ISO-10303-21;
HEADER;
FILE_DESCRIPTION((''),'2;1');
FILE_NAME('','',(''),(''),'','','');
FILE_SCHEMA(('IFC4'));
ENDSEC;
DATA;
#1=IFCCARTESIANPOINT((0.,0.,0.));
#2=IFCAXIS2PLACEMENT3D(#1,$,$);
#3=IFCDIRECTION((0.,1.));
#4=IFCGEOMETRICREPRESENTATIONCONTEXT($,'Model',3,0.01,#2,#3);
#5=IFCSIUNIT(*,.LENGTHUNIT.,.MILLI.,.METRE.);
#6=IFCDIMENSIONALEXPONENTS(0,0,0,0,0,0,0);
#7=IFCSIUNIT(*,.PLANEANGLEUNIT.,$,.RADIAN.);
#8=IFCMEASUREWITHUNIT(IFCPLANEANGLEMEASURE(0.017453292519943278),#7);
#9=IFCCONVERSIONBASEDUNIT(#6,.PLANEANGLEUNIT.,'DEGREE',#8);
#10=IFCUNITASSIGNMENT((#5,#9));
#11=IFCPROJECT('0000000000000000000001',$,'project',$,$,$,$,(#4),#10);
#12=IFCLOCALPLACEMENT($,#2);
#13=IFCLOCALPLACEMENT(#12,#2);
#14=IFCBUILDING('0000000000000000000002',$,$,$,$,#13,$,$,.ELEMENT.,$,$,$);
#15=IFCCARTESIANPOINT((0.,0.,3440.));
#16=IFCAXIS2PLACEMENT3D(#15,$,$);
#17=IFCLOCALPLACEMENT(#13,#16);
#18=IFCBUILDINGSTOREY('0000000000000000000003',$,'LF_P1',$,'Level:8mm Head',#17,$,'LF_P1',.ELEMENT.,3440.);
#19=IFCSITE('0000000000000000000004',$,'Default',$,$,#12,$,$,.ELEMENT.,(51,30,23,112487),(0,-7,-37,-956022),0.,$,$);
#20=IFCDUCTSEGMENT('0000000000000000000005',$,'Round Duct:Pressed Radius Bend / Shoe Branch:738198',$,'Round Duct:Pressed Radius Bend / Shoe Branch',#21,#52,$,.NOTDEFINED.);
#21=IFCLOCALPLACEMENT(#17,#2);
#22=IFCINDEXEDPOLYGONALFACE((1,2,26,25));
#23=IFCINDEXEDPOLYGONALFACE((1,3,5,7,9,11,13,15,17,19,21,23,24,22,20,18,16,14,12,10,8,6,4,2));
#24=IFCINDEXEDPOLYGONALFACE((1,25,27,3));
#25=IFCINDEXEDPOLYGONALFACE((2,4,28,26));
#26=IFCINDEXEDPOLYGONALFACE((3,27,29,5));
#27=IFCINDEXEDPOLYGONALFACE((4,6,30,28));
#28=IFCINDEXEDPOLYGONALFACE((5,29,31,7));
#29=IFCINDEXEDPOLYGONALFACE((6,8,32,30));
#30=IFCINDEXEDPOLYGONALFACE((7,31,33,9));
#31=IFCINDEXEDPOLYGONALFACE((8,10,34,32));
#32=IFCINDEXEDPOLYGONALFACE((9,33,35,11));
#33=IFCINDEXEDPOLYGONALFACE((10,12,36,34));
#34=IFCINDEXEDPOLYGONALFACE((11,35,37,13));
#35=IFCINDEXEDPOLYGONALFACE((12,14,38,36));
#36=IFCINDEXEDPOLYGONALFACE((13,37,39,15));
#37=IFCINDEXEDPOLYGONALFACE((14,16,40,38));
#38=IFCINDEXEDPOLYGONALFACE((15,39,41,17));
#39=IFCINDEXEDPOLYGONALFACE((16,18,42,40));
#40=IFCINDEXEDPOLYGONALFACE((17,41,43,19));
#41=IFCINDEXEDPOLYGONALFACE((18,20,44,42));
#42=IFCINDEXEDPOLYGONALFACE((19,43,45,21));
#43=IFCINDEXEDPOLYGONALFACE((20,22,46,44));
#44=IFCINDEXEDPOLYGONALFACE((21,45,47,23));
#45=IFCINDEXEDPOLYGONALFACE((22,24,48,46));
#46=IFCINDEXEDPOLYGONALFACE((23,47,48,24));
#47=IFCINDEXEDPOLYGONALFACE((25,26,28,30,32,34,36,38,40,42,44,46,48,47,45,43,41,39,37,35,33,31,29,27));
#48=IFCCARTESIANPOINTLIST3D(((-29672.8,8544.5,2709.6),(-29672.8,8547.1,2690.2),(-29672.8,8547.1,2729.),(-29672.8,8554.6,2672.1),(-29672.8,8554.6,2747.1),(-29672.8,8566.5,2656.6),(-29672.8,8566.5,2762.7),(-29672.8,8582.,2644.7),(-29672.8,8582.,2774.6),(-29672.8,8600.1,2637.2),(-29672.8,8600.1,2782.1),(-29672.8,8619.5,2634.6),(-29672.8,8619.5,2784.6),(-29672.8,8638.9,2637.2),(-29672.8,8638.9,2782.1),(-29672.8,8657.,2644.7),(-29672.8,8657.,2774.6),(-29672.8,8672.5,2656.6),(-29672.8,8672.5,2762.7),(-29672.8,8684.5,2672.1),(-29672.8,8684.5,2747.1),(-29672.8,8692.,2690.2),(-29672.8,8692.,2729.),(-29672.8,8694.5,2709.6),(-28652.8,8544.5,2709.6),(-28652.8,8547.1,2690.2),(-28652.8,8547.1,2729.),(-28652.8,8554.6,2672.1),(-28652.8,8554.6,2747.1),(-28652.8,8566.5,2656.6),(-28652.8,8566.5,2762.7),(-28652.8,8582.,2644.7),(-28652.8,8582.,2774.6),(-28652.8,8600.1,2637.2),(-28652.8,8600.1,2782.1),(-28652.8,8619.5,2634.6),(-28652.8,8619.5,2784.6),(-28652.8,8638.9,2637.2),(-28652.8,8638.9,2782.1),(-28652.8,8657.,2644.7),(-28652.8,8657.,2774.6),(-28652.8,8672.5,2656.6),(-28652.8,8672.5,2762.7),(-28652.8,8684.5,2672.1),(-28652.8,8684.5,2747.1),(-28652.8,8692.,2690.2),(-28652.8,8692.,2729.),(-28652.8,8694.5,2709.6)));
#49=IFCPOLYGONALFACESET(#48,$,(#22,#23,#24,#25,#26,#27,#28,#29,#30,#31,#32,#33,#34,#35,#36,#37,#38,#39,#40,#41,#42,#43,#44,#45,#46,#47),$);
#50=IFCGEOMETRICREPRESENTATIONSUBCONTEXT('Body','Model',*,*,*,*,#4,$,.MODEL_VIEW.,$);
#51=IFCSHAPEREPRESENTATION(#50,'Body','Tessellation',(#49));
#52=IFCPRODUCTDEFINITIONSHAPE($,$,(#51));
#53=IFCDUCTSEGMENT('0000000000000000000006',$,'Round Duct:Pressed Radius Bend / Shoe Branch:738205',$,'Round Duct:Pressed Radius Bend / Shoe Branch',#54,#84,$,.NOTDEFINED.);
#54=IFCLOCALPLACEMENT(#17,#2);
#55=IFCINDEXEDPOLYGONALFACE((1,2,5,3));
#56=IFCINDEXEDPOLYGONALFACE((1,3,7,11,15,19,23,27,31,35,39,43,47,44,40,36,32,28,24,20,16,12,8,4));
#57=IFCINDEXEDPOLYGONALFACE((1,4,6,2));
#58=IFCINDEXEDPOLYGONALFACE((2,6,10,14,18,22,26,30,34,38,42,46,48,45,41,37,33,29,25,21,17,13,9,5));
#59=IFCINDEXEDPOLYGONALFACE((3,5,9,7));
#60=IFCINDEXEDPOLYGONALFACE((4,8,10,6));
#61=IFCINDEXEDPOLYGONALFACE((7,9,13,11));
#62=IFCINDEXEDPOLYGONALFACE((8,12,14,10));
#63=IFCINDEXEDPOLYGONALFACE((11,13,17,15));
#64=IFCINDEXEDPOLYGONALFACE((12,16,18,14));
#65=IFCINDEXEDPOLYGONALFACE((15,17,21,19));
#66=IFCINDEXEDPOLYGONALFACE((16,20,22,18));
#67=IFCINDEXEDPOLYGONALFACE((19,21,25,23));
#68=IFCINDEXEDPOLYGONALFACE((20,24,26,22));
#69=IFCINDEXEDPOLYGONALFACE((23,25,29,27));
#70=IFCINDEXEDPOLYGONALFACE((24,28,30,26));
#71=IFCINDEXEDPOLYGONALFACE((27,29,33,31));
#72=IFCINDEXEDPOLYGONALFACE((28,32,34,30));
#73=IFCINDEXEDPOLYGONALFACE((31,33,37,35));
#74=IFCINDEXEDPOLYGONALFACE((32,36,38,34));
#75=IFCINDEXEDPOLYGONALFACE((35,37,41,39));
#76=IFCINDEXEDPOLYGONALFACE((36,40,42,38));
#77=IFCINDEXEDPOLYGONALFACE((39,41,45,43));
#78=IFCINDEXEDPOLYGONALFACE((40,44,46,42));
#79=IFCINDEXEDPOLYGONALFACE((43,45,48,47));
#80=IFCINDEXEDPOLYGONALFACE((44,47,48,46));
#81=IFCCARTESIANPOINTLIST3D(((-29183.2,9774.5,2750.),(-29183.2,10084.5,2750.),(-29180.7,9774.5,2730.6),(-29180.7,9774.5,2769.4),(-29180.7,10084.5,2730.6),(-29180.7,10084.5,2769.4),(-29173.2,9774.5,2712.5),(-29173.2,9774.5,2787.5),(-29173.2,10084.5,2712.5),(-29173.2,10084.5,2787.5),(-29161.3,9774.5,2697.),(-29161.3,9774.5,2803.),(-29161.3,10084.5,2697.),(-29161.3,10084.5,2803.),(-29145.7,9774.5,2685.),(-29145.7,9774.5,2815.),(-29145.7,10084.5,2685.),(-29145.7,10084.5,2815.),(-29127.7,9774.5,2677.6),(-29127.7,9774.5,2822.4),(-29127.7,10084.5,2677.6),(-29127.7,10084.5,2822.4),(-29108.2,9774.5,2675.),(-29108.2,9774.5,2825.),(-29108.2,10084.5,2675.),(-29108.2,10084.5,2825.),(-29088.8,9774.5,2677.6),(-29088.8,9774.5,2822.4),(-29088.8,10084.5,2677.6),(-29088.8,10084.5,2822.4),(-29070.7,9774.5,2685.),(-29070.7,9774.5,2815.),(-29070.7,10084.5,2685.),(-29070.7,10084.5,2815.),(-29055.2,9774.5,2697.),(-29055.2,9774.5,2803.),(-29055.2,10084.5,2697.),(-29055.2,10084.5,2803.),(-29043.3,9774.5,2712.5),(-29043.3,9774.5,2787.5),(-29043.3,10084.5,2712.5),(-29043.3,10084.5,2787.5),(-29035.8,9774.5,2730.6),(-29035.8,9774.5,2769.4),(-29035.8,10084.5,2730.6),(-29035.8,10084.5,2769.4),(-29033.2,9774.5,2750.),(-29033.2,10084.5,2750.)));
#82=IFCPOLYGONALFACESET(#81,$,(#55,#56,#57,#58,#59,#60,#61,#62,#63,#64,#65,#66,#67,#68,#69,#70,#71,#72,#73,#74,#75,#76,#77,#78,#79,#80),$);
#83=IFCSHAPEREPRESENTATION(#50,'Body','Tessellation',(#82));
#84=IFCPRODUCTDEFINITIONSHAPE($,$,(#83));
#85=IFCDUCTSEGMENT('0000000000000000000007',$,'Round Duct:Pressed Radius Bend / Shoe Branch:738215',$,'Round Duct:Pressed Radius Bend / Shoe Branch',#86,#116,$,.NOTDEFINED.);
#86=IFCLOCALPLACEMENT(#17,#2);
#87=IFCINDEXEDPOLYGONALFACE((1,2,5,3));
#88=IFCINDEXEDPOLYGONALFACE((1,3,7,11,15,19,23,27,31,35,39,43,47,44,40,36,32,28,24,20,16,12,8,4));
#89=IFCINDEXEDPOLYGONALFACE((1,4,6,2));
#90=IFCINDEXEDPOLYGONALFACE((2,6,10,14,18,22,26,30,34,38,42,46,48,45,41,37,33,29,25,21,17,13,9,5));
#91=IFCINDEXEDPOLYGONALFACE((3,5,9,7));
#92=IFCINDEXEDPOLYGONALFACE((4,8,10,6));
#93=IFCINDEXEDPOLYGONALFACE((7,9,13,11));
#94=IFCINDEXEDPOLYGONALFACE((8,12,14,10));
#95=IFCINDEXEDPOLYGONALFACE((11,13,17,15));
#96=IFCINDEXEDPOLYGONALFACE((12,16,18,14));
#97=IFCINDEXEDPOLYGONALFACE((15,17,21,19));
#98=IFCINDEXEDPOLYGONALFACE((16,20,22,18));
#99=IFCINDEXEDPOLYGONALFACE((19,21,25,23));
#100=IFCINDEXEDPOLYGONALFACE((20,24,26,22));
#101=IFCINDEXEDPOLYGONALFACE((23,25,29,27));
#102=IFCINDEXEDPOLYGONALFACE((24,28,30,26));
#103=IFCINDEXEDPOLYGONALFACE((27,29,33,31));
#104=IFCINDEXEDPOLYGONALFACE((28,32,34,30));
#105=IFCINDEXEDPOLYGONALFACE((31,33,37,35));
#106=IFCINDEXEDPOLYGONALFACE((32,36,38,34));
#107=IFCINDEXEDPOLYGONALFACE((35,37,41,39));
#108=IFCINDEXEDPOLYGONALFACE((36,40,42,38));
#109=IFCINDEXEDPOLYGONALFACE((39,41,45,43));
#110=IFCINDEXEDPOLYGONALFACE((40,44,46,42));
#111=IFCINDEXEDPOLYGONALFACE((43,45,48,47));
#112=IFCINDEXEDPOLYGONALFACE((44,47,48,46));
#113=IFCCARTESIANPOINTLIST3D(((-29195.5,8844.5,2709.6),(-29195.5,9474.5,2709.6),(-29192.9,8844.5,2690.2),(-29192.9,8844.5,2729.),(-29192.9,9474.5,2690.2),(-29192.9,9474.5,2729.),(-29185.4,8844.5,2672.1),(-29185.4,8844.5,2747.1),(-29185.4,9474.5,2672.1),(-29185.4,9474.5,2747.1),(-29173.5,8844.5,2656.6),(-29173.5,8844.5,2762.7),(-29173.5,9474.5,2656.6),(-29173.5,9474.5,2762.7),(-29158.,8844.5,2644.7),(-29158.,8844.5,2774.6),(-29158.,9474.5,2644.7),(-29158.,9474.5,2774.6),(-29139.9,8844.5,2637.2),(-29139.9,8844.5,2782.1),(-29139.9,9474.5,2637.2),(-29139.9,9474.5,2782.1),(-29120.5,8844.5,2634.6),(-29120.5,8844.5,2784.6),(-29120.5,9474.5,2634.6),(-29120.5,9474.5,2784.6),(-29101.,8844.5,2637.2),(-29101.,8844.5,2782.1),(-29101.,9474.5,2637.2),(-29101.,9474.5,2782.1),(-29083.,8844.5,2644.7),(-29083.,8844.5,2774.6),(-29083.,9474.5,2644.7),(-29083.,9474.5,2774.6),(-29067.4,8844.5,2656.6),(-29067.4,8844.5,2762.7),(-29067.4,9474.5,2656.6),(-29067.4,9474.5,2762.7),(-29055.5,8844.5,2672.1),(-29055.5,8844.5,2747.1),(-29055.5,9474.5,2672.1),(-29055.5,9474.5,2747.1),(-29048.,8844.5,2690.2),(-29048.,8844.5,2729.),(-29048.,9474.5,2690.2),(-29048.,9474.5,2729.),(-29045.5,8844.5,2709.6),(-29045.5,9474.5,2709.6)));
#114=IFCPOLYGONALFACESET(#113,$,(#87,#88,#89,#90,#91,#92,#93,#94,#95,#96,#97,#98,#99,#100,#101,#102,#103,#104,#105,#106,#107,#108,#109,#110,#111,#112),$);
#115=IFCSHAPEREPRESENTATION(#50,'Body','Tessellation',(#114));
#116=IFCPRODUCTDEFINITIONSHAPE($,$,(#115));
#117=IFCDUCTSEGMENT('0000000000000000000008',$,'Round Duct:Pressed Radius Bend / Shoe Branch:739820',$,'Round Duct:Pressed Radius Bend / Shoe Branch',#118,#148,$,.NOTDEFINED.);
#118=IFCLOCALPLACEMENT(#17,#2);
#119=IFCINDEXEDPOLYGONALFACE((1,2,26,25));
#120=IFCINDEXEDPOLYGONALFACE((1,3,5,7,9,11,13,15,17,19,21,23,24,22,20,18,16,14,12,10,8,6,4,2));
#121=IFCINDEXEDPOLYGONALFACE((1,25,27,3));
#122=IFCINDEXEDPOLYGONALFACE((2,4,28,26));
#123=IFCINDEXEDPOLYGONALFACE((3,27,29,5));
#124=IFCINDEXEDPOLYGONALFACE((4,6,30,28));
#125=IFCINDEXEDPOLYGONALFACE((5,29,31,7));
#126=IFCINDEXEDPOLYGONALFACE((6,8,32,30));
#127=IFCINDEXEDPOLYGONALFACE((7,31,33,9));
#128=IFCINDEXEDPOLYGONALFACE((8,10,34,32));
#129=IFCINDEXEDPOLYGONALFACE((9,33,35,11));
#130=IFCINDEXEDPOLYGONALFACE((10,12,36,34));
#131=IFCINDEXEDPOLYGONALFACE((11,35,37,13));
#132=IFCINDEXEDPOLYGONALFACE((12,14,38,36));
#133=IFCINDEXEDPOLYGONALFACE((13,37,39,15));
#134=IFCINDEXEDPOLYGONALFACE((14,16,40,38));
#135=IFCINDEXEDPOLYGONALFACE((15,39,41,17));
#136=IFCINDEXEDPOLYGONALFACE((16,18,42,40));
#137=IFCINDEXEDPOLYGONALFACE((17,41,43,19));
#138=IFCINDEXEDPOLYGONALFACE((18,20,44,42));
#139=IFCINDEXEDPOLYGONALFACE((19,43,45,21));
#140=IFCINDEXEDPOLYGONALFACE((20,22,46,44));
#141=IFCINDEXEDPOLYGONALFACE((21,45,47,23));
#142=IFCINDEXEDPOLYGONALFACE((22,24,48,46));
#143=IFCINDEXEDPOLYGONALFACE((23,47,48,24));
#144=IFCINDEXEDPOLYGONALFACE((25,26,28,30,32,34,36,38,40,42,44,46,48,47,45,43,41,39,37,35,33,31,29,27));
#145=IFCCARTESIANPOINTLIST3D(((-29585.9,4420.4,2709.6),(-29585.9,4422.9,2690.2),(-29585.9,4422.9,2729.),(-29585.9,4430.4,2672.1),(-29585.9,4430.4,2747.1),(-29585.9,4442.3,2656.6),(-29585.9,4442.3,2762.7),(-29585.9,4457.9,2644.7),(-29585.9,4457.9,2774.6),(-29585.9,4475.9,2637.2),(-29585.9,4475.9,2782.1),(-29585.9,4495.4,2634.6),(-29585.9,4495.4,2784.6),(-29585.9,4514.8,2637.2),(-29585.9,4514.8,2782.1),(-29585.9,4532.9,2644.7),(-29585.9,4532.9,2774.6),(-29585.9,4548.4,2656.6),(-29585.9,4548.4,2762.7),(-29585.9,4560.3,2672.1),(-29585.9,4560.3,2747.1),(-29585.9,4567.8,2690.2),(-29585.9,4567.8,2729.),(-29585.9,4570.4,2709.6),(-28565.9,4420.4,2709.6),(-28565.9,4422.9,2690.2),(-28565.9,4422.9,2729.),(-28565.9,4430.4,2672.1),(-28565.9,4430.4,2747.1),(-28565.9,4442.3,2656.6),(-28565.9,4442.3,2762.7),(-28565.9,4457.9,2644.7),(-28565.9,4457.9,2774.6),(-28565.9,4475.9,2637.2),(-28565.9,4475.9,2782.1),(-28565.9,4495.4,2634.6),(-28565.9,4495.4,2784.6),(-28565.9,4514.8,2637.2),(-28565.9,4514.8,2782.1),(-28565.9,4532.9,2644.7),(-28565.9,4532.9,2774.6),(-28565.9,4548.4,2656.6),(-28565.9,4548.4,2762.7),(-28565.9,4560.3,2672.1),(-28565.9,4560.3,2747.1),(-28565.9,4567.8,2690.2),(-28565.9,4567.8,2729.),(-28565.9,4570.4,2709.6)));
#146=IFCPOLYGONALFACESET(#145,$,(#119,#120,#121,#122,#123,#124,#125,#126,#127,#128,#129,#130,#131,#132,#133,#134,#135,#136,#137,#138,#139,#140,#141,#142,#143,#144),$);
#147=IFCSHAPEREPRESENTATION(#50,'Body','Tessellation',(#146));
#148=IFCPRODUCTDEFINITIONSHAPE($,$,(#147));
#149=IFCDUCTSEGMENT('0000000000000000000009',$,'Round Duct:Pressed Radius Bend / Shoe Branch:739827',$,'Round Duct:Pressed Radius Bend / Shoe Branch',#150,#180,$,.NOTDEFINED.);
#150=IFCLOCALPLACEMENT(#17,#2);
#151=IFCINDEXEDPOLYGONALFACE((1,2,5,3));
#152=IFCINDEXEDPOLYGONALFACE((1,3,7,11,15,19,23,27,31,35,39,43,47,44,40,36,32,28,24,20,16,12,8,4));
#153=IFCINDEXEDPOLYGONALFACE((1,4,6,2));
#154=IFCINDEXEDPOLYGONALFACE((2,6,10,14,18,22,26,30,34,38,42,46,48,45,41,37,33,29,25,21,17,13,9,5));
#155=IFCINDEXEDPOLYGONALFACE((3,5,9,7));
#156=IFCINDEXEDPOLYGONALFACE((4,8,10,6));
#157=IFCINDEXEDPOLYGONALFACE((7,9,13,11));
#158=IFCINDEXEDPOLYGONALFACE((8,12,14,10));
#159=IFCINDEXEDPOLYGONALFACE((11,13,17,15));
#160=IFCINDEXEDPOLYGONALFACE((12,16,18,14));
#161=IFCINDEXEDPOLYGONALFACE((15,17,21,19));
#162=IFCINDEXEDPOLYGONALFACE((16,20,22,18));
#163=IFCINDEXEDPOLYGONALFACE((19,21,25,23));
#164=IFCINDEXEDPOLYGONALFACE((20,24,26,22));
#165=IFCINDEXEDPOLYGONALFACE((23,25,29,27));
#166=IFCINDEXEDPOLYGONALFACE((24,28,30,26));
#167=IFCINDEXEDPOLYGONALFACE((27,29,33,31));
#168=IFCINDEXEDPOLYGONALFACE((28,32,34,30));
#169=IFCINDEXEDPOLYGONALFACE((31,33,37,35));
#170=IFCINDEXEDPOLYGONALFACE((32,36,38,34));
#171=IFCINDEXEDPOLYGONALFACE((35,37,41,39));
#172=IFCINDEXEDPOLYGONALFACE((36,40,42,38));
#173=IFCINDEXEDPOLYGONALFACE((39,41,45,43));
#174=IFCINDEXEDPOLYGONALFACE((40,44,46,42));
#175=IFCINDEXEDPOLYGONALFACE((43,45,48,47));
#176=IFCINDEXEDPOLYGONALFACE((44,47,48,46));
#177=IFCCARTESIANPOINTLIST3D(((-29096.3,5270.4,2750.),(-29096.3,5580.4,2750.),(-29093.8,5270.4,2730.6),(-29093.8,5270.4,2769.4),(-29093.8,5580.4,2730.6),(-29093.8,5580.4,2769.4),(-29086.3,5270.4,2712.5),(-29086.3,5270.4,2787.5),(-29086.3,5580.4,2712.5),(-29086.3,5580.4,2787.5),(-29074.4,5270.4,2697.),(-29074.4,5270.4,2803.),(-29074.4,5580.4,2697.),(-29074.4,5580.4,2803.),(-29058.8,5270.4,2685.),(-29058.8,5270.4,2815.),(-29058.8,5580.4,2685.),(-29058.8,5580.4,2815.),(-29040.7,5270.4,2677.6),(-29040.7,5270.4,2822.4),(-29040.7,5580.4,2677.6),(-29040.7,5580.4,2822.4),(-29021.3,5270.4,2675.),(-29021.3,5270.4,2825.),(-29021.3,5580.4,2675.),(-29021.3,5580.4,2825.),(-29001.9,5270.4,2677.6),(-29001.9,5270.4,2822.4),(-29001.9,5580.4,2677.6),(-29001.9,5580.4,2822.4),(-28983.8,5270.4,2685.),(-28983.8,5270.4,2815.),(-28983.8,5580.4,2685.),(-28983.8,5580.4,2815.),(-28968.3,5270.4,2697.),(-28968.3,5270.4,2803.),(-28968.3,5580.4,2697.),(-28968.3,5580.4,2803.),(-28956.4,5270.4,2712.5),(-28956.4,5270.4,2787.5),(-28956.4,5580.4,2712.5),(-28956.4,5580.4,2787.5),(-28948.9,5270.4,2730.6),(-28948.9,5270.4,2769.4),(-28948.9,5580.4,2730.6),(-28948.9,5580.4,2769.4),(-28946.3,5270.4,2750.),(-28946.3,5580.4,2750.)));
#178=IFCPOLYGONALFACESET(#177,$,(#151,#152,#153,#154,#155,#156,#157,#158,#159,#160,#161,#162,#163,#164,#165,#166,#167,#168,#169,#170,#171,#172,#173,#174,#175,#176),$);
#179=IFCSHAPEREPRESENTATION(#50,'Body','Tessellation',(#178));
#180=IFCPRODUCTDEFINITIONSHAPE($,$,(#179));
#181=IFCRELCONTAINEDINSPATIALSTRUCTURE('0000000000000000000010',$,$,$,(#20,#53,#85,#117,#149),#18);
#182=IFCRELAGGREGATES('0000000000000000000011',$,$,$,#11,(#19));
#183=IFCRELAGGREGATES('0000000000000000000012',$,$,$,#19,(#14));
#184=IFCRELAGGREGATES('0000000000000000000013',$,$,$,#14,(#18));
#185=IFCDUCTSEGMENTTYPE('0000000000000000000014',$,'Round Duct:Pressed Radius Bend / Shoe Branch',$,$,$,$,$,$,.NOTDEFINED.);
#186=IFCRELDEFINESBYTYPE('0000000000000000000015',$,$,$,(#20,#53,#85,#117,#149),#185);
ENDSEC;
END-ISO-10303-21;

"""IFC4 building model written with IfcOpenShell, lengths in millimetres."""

from ifc_helpers import new_model, entity, si_unit, converted_unit, direction, frame, origin, place, context, subcontext, project, spatial, arc, indexed_curve, outline, extrude, type_object, element, save


model = new_model("IFC4")

# Units and contexts
model_context = context("Model", 3, precision=0.01, world=origin(), true_north=direction((0.0, 1.0)))
body_context = subcontext(model_context, "Body", "Model", "MODEL_VIEW")
ifc_project = project(units=[si_unit("LENGTHUNIT", "METRE", prefix="MILLI"), converted_unit("PLANEANGLEUNIT", "DEGREE", entity("IfcPlaneAngleMeasure", 0.017453292519943278), si_unit("PLANEANGLEUNIT", "RADIAN"), dimensions=[0, 0, 0, 0, 0, 0, 0])], contexts=[model_context])

# Site, building, storey
site_placement = place(None, origin())
site = spatial("IfcSite", under=ifc_project, at=site_placement, Name="Default", CompositionType="ELEMENT", RefLatitude=(51, 30, 23, 112487), RefLongitude=(0, -7, -37, -956022), RefElevation=0.0)
building_placement = place(site_placement, origin())
building = spatial("IfcBuilding", under=site, at=building_placement, CompositionType="ELEMENT")
storey_placement = place(building_placement, frame((0.0, 0.0, 3440.0)))
storey = spatial("IfcBuildingStorey", under=building, at=storey_placement, Name="LF_P1", ObjectType="Level:8mm Head", LongName="LF_P1", CompositionType="ELEMENT", Elevation=3440.0)

# Duct segments
duct_segment_type_1 = type_object("IfcDuctSegmentType", Name="Round Duct:Pressed Radius Bend / Shoe Branch", PredefinedType="NOTDEFINED")
duct_segment_1_placement = place(storey_placement, origin())
element("IfcDuctSegment", 1, at=duct_segment_1_placement, inside=storey, type_object=duct_segment_type_1, Name="Round Duct:Pressed Radius Bend / Shoe Branch:738198", ObjectType="Round Duct:Pressed Radius Bend / Shoe Branch", PredefinedType="NOTDEFINED", context=body_context, shape_type="SweptSolid", body=[
    extrude(outline(indexed_curve([(75.0, 0.0), (53.0, 53.0), (0.0, 75.0), (-53.0, 53.0), (-75.0, 0.0), (-53.0, -53.0), (0.0, -75.0), (53.0, -53.0)], segments=[arc(1, 2, 3), arc(3, 4, 5), arc(5, 6, 7), arc(7, 8, 1)], self_intersect=False)), frame((-29672.8, 8619.5, 2709.6), z_axis=(1.0, 0.0, 0.0), x_axis=(0.0, 1.0, 0.0)), (0.0, 0.0, 1.0), 1020.0),
])
duct_segment_2_placement = place(storey_placement, origin())
element("IfcDuctSegment", 2, at=duct_segment_2_placement, inside=storey, type_object=duct_segment_type_1, Name="Round Duct:Pressed Radius Bend / Shoe Branch:738205", ObjectType="Round Duct:Pressed Radius Bend / Shoe Branch", PredefinedType="NOTDEFINED", context=body_context, shape_type="SweptSolid", body=[
    extrude(outline(indexed_curve([(75.0, 0.0), (53.0, 53.0), (0.0, 75.0), (-53.0, 53.0), (-75.0, 0.0), (-53.0, -53.0), (0.0, -75.0), (53.0, -53.0)], segments=[arc(1, 2, 3), arc(3, 4, 5), arc(5, 6, 7), arc(7, 8, 1)], self_intersect=False)), frame((-29108.2, 9774.5, 2750.0), z_axis=(0.0, 1.0, 0.0), x_axis=(-1.0, 0.0, 0.0)), (0.0, 0.0, 1.0), 310.0),
])
duct_segment_3_placement = place(storey_placement, origin())
element("IfcDuctSegment", 3, at=duct_segment_3_placement, inside=storey, type_object=duct_segment_type_1, Name="Round Duct:Pressed Radius Bend / Shoe Branch:738215", ObjectType="Round Duct:Pressed Radius Bend / Shoe Branch", PredefinedType="NOTDEFINED", context=body_context, shape_type="SweptSolid", body=[
    extrude(outline(indexed_curve([(75.0, 0.0), (53.0, 53.0), (0.0, 75.0), (-53.0, 53.0), (-75.0, 0.0), (-53.0, -53.0), (0.0, -75.0), (53.0, -53.0)], segments=[arc(1, 2, 3), arc(3, 4, 5), arc(5, 6, 7), arc(7, 8, 1)], self_intersect=False)), frame((-29120.5, 8844.5, 2709.6), z_axis=(0.0, 1.0, 0.0), x_axis=(1.0, 0.0, 0.0)), (0.0, 0.0, 1.0), 630.0),
])
duct_segment_4_placement = place(storey_placement, origin())
element("IfcDuctSegment", 4, at=duct_segment_4_placement, inside=storey, type_object=duct_segment_type_1, Name="Round Duct:Pressed Radius Bend / Shoe Branch:739820", ObjectType="Round Duct:Pressed Radius Bend / Shoe Branch", PredefinedType="NOTDEFINED", context=body_context, shape_type="SweptSolid", body=[
    extrude(outline(indexed_curve([(75.0, 0.0), (53.0, 53.0), (0.0, 75.0), (-53.0, 53.0), (-75.0, 0.0), (-53.0, -53.0), (0.0, -75.0), (53.0, -53.0)], segments=[arc(1, 2, 3), arc(3, 4, 5), arc(5, 6, 7), arc(7, 8, 1)], self_intersect=False)), frame((-29585.9, 4495.4, 2709.6), z_axis=(1.0, 0.0, 0.0), x_axis=(0.0, 1.0, 0.0)), (0.0, 0.0, 1.0), 1020.0),
])
duct_segment_5_placement = place(storey_placement, origin())
element("IfcDuctSegment", 5, at=duct_segment_5_placement, inside=storey, type_object=duct_segment_type_1, Name="Round Duct:Pressed Radius Bend / Shoe Branch:739827", ObjectType="Round Duct:Pressed Radius Bend / Shoe Branch", PredefinedType="NOTDEFINED", context=body_context, shape_type="SweptSolid", body=[
    extrude(outline(indexed_curve([(75.0, 0.0), (53.0, 53.0), (0.0, 75.0), (-53.0, 53.0), (-75.0, 0.0), (-53.0, -53.0), (0.0, -75.0), (53.0, -53.0)], segments=[arc(1, 2, 3), arc(3, 4, 5), arc(5, 6, 7), arc(7, 8, 1)], self_intersect=False)), frame((-29021.3, 5270.4, 2750.0), z_axis=(0.0, 1.0, 0.0), x_axis=(-1.0, 0.0, 0.0)), (0.0, 0.0, 1.0), 310.0),
])

save(model, "model.ifc")
